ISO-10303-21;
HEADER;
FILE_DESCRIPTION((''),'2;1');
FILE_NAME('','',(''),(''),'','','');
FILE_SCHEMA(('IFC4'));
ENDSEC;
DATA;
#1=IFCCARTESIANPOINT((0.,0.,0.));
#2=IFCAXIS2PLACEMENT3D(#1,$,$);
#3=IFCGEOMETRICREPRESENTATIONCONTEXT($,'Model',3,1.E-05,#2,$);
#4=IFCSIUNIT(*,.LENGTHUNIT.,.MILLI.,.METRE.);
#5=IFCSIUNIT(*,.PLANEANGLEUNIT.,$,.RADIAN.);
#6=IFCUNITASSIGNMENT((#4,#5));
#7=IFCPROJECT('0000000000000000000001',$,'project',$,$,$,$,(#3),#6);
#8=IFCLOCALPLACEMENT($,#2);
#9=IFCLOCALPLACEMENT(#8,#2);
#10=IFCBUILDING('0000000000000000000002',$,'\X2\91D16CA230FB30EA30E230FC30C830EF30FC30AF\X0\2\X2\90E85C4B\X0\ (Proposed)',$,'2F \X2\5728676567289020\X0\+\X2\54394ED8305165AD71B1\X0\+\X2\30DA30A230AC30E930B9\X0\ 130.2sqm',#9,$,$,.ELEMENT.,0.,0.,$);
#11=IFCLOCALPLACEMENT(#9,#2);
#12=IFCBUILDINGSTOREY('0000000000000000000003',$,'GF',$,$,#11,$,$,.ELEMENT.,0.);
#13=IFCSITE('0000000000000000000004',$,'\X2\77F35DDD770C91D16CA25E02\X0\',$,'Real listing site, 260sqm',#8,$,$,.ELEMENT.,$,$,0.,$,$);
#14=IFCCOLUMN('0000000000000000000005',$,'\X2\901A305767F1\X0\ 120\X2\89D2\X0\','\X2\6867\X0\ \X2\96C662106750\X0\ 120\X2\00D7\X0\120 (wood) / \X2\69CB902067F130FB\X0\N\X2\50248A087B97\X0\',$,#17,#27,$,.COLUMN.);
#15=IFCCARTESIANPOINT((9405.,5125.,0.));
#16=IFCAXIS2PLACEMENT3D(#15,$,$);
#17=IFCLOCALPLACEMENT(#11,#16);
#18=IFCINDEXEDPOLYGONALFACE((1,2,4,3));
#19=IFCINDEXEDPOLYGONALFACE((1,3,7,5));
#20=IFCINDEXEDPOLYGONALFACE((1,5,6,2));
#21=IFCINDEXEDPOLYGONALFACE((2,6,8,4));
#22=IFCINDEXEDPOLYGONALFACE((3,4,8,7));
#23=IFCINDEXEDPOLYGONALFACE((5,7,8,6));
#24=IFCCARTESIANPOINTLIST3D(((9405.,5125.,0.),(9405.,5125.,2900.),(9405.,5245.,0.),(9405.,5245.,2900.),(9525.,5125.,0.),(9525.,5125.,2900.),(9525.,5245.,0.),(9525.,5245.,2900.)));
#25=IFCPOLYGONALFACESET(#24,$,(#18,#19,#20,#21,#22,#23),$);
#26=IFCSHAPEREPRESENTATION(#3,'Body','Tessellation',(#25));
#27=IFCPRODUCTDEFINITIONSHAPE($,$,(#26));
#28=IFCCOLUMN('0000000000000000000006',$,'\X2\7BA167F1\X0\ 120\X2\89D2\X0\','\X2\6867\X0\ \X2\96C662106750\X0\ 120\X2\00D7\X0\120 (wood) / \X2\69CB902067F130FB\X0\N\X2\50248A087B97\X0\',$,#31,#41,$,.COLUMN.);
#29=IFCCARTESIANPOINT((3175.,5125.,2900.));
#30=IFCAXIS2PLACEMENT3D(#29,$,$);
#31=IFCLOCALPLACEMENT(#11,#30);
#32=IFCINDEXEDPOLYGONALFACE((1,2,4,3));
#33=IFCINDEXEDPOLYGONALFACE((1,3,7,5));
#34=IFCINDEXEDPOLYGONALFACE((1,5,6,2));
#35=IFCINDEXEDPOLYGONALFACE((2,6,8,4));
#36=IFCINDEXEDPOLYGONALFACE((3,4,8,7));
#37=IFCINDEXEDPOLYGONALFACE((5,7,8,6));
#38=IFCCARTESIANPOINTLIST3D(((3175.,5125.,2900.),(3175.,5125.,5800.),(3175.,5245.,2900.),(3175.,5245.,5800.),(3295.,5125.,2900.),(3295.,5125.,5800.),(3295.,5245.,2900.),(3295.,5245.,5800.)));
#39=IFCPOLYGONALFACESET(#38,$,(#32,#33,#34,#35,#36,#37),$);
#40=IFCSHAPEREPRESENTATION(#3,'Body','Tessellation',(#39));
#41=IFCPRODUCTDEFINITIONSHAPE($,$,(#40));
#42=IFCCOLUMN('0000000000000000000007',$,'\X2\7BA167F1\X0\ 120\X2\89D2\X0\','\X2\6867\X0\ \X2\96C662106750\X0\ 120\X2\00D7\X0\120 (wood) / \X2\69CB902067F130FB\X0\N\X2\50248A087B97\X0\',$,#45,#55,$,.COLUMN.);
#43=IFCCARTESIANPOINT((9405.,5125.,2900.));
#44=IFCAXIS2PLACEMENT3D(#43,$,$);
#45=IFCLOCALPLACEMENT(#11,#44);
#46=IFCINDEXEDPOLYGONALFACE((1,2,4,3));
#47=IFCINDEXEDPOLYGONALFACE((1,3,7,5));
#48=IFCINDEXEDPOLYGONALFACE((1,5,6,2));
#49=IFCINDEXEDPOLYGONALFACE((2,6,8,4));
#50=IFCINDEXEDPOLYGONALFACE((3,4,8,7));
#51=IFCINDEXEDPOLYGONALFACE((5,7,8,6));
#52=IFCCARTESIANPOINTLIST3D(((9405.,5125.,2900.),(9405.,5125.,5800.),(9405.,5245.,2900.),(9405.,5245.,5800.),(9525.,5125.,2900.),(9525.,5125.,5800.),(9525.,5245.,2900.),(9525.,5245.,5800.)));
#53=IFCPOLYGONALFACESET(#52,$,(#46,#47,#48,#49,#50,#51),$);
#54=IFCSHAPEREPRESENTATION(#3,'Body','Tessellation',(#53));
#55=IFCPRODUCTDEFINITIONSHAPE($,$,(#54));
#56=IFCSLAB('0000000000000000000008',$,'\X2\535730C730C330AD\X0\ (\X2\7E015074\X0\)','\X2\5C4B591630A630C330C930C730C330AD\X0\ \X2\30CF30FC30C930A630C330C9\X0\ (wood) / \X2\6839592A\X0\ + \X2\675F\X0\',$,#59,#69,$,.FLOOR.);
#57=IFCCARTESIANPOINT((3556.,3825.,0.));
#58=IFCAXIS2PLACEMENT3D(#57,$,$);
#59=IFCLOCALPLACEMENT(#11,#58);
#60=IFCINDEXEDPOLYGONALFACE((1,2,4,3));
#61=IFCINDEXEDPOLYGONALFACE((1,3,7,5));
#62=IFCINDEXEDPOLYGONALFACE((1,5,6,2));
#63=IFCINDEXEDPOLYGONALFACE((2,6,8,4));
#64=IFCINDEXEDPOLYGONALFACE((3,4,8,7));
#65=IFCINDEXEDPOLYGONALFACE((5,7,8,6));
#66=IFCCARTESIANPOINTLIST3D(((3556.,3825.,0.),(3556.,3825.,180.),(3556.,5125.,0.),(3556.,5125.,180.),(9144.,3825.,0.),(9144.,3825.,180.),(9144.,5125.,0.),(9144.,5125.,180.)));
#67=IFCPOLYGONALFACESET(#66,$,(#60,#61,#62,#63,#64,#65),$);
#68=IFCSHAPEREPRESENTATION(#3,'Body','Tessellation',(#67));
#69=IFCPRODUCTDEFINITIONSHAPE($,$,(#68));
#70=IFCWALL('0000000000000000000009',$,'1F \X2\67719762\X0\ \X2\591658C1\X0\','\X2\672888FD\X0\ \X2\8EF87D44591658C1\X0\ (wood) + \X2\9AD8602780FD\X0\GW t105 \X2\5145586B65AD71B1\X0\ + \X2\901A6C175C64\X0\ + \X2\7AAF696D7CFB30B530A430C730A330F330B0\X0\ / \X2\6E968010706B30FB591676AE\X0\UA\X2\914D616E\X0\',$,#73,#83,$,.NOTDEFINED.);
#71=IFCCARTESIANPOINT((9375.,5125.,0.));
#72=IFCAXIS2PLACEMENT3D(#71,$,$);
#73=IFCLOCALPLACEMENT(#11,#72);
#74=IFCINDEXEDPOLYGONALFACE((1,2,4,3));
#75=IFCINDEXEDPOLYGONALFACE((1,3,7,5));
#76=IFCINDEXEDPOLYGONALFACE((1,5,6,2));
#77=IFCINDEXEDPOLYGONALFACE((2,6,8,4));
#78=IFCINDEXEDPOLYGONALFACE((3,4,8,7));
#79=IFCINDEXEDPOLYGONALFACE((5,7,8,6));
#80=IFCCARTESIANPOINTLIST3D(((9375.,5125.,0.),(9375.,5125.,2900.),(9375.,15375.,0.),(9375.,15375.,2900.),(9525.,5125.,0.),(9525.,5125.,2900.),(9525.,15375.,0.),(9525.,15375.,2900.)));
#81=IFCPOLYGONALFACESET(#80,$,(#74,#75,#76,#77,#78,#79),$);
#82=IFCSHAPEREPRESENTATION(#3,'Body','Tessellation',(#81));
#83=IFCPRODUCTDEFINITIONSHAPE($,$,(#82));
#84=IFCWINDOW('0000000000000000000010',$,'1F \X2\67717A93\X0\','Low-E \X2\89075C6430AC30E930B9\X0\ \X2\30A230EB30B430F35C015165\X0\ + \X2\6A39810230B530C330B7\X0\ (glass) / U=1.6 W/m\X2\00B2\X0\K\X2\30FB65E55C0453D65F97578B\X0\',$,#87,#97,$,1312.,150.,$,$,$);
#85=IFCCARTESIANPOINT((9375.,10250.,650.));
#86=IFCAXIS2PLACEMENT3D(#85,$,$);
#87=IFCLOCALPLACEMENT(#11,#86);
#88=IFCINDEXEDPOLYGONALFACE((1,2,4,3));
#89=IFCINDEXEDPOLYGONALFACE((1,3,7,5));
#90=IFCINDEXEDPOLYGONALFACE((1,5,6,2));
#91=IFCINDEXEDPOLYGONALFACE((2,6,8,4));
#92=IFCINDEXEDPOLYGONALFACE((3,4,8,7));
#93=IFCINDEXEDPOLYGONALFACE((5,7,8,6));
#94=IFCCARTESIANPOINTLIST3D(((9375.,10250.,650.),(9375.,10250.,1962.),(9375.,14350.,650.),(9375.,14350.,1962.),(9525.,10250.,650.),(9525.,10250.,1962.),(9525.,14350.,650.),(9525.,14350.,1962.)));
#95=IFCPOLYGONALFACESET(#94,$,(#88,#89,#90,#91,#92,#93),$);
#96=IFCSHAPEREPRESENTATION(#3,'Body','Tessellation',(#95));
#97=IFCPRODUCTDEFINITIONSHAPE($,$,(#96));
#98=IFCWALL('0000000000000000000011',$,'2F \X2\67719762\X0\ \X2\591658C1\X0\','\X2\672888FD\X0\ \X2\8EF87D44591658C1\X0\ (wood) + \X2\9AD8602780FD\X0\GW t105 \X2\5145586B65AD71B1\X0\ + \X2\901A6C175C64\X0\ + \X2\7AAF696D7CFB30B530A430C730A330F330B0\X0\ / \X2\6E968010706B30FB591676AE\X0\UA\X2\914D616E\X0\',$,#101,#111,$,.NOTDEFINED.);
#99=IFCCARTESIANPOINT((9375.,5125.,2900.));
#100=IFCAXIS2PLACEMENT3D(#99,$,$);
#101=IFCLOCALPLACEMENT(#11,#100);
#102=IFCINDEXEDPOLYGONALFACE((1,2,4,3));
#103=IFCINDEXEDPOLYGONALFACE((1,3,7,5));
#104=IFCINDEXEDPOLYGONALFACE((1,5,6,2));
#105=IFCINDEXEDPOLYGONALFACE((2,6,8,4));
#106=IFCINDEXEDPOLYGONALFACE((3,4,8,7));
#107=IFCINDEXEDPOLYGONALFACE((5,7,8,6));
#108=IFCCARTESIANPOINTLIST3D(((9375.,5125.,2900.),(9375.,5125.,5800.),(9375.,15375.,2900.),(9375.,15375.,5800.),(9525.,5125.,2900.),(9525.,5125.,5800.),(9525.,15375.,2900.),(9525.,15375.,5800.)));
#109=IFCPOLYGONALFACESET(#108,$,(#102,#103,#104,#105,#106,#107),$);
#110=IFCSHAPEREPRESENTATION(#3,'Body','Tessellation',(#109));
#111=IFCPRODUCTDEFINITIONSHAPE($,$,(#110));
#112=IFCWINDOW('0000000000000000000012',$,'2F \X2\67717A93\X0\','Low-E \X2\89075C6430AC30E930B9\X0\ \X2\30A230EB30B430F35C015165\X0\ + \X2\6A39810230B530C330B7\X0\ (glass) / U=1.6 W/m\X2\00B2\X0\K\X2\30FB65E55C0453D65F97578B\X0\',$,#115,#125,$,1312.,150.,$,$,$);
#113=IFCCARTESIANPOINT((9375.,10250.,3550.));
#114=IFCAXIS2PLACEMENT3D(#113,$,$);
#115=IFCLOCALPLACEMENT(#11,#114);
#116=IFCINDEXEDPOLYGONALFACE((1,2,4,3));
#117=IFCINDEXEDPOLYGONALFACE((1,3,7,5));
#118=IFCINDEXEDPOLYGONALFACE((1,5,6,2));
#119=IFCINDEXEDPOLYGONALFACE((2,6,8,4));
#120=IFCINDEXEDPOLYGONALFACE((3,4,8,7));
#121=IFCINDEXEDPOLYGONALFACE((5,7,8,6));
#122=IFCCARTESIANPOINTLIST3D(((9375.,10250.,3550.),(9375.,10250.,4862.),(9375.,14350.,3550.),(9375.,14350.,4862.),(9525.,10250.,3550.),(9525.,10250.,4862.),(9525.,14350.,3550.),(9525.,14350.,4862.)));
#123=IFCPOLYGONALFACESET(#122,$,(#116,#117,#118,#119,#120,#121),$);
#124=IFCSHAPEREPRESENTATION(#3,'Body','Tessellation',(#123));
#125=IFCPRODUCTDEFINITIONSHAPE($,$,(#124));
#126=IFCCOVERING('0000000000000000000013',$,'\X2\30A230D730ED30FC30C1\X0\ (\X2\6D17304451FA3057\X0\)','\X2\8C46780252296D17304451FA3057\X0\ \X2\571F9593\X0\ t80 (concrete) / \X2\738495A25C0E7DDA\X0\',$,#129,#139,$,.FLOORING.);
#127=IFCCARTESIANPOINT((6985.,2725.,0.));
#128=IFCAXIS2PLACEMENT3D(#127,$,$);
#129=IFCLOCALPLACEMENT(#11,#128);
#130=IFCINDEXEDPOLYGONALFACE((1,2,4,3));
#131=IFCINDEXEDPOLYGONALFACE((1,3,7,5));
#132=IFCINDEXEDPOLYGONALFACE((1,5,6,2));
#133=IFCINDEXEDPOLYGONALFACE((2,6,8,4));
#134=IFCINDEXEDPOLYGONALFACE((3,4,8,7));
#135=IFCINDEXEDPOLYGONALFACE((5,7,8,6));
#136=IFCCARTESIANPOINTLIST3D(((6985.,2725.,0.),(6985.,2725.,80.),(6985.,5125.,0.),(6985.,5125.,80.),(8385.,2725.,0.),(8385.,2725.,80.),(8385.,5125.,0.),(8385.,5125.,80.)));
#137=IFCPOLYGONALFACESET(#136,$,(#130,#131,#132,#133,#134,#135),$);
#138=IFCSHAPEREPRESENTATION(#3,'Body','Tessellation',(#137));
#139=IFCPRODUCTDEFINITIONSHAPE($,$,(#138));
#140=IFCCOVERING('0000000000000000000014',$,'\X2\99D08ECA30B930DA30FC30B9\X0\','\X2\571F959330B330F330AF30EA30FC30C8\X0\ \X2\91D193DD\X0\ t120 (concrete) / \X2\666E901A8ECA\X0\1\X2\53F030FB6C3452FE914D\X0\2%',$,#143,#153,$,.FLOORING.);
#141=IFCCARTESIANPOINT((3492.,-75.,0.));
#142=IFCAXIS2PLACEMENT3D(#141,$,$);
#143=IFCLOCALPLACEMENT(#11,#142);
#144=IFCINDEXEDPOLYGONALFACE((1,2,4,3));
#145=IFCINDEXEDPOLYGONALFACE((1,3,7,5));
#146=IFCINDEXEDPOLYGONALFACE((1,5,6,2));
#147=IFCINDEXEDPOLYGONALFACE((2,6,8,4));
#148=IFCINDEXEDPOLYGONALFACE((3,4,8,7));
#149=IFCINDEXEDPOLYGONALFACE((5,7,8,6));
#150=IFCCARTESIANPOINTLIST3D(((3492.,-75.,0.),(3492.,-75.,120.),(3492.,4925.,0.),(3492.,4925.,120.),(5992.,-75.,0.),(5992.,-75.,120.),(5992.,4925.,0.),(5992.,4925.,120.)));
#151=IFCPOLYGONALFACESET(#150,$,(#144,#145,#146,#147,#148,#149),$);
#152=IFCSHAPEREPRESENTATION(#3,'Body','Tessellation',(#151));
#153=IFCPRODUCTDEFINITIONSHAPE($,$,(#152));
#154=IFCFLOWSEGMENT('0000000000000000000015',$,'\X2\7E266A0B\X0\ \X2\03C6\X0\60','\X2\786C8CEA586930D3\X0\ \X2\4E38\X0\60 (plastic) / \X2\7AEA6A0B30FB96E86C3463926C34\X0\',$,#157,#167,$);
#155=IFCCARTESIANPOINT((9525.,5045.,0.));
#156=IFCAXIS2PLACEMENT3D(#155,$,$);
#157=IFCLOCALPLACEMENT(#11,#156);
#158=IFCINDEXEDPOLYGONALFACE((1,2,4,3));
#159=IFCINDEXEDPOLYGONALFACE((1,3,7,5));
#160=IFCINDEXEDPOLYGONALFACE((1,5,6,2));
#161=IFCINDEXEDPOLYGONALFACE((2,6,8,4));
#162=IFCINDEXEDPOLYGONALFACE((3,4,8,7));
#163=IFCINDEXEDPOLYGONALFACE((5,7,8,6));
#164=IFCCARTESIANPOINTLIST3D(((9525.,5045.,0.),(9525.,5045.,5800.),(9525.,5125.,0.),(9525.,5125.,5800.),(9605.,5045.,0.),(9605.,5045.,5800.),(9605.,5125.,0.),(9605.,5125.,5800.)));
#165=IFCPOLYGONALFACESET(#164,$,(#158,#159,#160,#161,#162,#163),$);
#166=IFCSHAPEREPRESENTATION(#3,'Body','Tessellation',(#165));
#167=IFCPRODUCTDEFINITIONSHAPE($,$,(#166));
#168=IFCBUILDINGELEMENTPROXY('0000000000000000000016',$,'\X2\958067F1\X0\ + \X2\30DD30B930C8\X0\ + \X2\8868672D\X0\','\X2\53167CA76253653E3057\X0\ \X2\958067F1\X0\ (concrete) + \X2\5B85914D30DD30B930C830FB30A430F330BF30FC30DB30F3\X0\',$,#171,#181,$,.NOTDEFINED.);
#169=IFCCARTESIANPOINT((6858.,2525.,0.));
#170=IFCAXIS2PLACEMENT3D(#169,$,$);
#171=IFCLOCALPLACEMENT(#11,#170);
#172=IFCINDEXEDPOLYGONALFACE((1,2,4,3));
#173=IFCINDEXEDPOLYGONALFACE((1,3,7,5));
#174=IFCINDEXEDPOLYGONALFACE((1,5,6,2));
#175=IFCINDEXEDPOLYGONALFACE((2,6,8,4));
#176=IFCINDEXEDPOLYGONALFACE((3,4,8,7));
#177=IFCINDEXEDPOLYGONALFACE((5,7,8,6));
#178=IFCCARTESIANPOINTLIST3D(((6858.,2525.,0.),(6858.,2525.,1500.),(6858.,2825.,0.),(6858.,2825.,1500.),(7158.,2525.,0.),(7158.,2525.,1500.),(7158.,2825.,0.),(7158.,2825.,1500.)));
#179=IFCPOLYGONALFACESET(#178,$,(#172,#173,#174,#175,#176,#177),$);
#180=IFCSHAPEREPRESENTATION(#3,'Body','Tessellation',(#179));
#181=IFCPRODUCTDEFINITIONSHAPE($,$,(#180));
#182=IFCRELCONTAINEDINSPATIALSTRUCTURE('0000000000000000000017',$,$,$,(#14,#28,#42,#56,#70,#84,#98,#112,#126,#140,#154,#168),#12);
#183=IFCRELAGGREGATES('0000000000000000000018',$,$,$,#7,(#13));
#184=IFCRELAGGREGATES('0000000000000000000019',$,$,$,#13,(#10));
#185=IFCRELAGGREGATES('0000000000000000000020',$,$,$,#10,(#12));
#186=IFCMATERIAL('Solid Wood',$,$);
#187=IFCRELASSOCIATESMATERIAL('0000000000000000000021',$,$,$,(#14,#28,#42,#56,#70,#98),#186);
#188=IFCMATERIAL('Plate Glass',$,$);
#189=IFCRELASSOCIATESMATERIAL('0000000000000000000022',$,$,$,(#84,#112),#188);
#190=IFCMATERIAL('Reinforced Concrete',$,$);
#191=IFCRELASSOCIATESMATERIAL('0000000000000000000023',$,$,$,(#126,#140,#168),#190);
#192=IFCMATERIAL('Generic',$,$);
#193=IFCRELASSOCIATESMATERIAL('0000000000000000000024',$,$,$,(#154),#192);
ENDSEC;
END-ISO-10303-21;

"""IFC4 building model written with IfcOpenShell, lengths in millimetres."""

from ifc_helpers import new_model, si_unit, frame, frame_2d, origin, place, context, project, spatial, rectangle, extrude, material, element, fill, save


model = new_model("IFC4")

# Units and contexts
model_context = context("Model", 3, precision=1e-05, world=origin())
ifc_project = project(units=[si_unit("LENGTHUNIT", "METRE", prefix="MILLI"), si_unit("PLANEANGLEUNIT", "RADIAN")], contexts=[model_context])

# Site, building, storey
site_placement = place(None, origin())
site = spatial("IfcSite", under=ifc_project, at=site_placement, Name="石川県金沢市", ObjectType="Real listing site, 260sqm", CompositionType="ELEMENT", RefElevation=0.0)
building_placement = place(site_placement, origin())
building = spatial("IfcBuilding", under=site, at=building_placement, Name="金沢・リモートワーク2部屋 (Proposed)", ObjectType="2F 在来木造+吹付け断熱+ペアガラス 130.2sqm", CompositionType="ELEMENT", ElevationOfRefHeight=0.0, ElevationOfTerrain=0.0)
storey_placement = place(building_placement, origin())
storey = spatial("IfcBuildingStorey", under=building, at=storey_placement, Name="GF", CompositionType="ELEMENT", Elevation=0.0)

# Columns
ifc_material_1 = material(Name="Solid Wood")
column_1_placement = place(storey_placement, frame((9405.0, 5125.0, 0.0)))
element("IfcColumn", 1, at=column_1_placement, inside=storey, material=ifc_material_1, Name="通し柱 120角", Description="桧 集成材 120×120 (wood) / 構造柱・N値計算", PredefinedType="COLUMN", context=model_context, shape_type="SweptSolid", body=[
    extrude(rectangle(XDim=120.0, YDim=120.0, at=frame_2d((60.0, 60.0))), frame((9405.0, 5125.0, 0.0)), (0.0, 0.0, 1.0), 2900.0),
])
column_2_placement = place(storey_placement, frame((3175.0, 5125.0, 2900.0)))
element("IfcColumn", 2, at=column_2_placement, inside=storey, material=ifc_material_1, Name="管柱 120角", Description="桧 集成材 120×120 (wood) / 構造柱・N値計算", PredefinedType="COLUMN", context=model_context, shape_type="SweptSolid", body=[
    extrude(rectangle(XDim=120.0, YDim=120.0, at=frame_2d((60.0, 60.0))), frame((3175.0, 5125.0, 2900.0)), (0.0, 0.0, 1.0), 2900.0),
])
column_3_placement = place(storey_placement, frame((9405.0, 5125.0, 2900.0)))
element("IfcColumn", 3, at=column_3_placement, inside=storey, material=ifc_material_1, Name="管柱 120角", Description="桧 集成材 120×120 (wood) / 構造柱・N値計算", PredefinedType="COLUMN", context=model_context, shape_type="SweptSolid", body=[
    extrude(rectangle(XDim=120.0, YDim=120.0, at=frame_2d((60.0, 60.0))), frame((9405.0, 5125.0, 2900.0)), (0.0, 0.0, 1.0), 2900.0),
])

# Slab
slab_placement = place(storey_placement, frame((3556.0, 3825.0, 0.0)))
element("IfcSlab", 4, at=slab_placement, inside=storey, material=ifc_material_1, Name="南デッキ (縁側)", Description="屋外ウッドデッキ ハードウッド (wood) / 根太 + 束", PredefinedType="FLOOR", context=model_context, shape_type="SweptSolid", body=[
    extrude(rectangle(XDim=5588.0, YDim=1300.0, at=frame_2d((2794.0, 650.0))), frame((3556.0, 3825.0, 0.0)), (0.0, 0.0, 1.0), 180.0),
])

# Walls, openings, windows
wall_1_placement = place(storey_placement, frame((9375.0, 5125.0, 0.0)))
wall_1 = element("IfcWall", 5, at=wall_1_placement, inside=storey, material=ifc_material_1, Name="1F 東面 外壁", Description="木製 軸組外壁 (wood) + 高性能GW t105 充填断熱 + 通気層 + 窯業系サイディング / 準耐火・外皮UA配慮", PredefinedType="NOTDEFINED", context=model_context, shape_type="SweptSolid", body=[
    extrude(rectangle(XDim=150.0, YDim=10250.0, at=frame_2d((75.0, 5125.0))), frame((9375.0, 5125.0, 0.0)), (0.0, 0.0, 1.0), 2900.0),
])
opening_1_placement = place(storey_placement, frame((9375.0, 10250.0, 650.0)))
opening_1 = element("IfcOpeningElement", 6, at=opening_1_placement, cuts=wall_1, PredefinedType="NOTDEFINED", context=model_context, shape_type="SweptSolid", body=[
    extrude(rectangle(XDim=150.0, YDim=4100.0, at=frame_2d((75.0, 2050.0))), frame((9375.0, 10250.0, 650.0)), (0.0, 0.0, 1.0), 1312.0),
])
ifc_material_2 = material(Name="Plate Glass")
window_1_placement = place(storey_placement, frame((9375.0, 10250.0, 650.0)))
window_1 = element("IfcWindow", 7, at=window_1_placement, inside=storey, material=ifc_material_2, Name="1F 東窓", Description="Low-E 複層ガラス アルゴン封入 + 樹脂サッシ (glass) / U=1.6 W/m²K・日射取得型", OverallHeight=1312.0, OverallWidth=150.0, context=model_context, shape_type="SweptSolid", body=[
    extrude(rectangle(XDim=150.0, YDim=4100.0, at=frame_2d((75.0, 2050.0))), frame((9375.0, 10250.0, 650.0)), (0.0, 0.0, 1.0), 1312.0),
])
fill(opening_1, window_1)
wall_2_placement = place(storey_placement, frame((9375.0, 5125.0, 2900.0)))
wall_2 = element("IfcWall", 8, at=wall_2_placement, inside=storey, material=ifc_material_1, Name="2F 東面 外壁", Description="木製 軸組外壁 (wood) + 高性能GW t105 充填断熱 + 通気層 + 窯業系サイディング / 準耐火・外皮UA配慮", PredefinedType="NOTDEFINED", context=model_context, shape_type="SweptSolid", body=[
    extrude(rectangle(XDim=150.0, YDim=10250.0, at=frame_2d((75.0, 5125.0))), frame((9375.0, 5125.0, 2900.0)), (0.0, 0.0, 1.0), 2900.0),
])
opening_2_placement = place(storey_placement, frame((9375.0, 10250.0, 3550.0)))
opening_2 = element("IfcOpeningElement", 9, at=opening_2_placement, cuts=wall_2, PredefinedType="NOTDEFINED", context=model_context, shape_type="SweptSolid", body=[
    extrude(rectangle(XDim=150.0, YDim=4100.0, at=frame_2d((75.0, 2050.0))), frame((9375.0, 10250.0, 3550.0)), (0.0, 0.0, 1.0), 1312.0),
])
window_2_placement = place(storey_placement, frame((9375.0, 10250.0, 3550.0)))
window_2 = element("IfcWindow", 10, at=window_2_placement, inside=storey, material=ifc_material_2, Name="2F 東窓", Description="Low-E 複層ガラス アルゴン封入 + 樹脂サッシ (glass) / U=1.6 W/m²K・日射取得型", OverallHeight=1312.0, OverallWidth=150.0, context=model_context, shape_type="SweptSolid", body=[
    extrude(rectangle(XDim=150.0, YDim=4100.0, at=frame_2d((75.0, 2050.0))), frame((9375.0, 10250.0, 3550.0)), (0.0, 0.0, 1.0), 1312.0),
])
fill(opening_2, window_2)

# Coverings
ifc_material_3 = material(Name="Reinforced Concrete")
covering_1_placement = place(storey_placement, frame((6985.0, 2725.0, 0.0)))
element("IfcCovering", 11, at=covering_1_placement, inside=storey, material=ifc_material_3, Name="アプローチ (洗い出し)", Description="豆砂利洗い出し 土間 t80 (concrete) / 玄関導線", PredefinedType="FLOORING", context=model_context, shape_type="SweptSolid", body=[
    extrude(rectangle(XDim=1400.0, YDim=2400.0, at=frame_2d((700.0, 1200.0))), frame((6985.0, 2725.0, 0.0)), (0.0, 0.0, 1.0), 80.0),
])
covering_2_placement = place(storey_placement, frame((3492.0, -75.0, 0.0)))
element("IfcCovering", 12, at=covering_2_placement, inside=storey, material=ifc_material_3, Name="駐車スペース", Description="土間コンクリート 金鏝 t120 (concrete) / 普通車1台・水勾配2%", PredefinedType="FLOORING", context=model_context, shape_type="SweptSolid", body=[
    extrude(rectangle(XDim=2500.0, YDim=5000.0, at=frame_2d((1250.0, 2500.0))), frame((3492.0, -75.0, 0.0)), (0.0, 0.0, 1.0), 120.0),
])

# Flow segment
ifc_material_4 = material(Name="Generic")
flow_segment_placement = place(storey_placement, frame((9525.0, 5045.0, 0.0)))
element("IfcFlowSegment", 13, at=flow_segment_placement, inside=storey, material=ifc_material_4, Name="縦樋 φ60", Description="硬質塩ビ 丸60 (plastic) / 竪樋・雨水排水", context=model_context, shape_type="SweptSolid", body=[
    extrude(rectangle(XDim=80.0, YDim=80.0, at=frame_2d((40.0, 40.0))), frame((9525.0, 5045.0, 0.0)), (0.0, 0.0, 1.0), 5800.0),
])

# Building element proxy
proxy_placement = place(storey_placement, frame((6858.0, 2525.0, 0.0)))
element("IfcBuildingElementProxy", 14, at=proxy_placement, inside=storey, material=ifc_material_3, Name="門柱 + ポスト + 表札", Description="化粧打放し 門柱 (concrete) + 宅配ポスト・インターホン", PredefinedType="NOTDEFINED", context=model_context, shape_type="SweptSolid", body=[
    extrude(rectangle(XDim=300.0, YDim=300.0, at=frame_2d((150.0, 150.0))), frame((6858.0, 2525.0, 0.0)), (0.0, 0.0, 1.0), 1500.0),
])

save(model, "model.ifc")
